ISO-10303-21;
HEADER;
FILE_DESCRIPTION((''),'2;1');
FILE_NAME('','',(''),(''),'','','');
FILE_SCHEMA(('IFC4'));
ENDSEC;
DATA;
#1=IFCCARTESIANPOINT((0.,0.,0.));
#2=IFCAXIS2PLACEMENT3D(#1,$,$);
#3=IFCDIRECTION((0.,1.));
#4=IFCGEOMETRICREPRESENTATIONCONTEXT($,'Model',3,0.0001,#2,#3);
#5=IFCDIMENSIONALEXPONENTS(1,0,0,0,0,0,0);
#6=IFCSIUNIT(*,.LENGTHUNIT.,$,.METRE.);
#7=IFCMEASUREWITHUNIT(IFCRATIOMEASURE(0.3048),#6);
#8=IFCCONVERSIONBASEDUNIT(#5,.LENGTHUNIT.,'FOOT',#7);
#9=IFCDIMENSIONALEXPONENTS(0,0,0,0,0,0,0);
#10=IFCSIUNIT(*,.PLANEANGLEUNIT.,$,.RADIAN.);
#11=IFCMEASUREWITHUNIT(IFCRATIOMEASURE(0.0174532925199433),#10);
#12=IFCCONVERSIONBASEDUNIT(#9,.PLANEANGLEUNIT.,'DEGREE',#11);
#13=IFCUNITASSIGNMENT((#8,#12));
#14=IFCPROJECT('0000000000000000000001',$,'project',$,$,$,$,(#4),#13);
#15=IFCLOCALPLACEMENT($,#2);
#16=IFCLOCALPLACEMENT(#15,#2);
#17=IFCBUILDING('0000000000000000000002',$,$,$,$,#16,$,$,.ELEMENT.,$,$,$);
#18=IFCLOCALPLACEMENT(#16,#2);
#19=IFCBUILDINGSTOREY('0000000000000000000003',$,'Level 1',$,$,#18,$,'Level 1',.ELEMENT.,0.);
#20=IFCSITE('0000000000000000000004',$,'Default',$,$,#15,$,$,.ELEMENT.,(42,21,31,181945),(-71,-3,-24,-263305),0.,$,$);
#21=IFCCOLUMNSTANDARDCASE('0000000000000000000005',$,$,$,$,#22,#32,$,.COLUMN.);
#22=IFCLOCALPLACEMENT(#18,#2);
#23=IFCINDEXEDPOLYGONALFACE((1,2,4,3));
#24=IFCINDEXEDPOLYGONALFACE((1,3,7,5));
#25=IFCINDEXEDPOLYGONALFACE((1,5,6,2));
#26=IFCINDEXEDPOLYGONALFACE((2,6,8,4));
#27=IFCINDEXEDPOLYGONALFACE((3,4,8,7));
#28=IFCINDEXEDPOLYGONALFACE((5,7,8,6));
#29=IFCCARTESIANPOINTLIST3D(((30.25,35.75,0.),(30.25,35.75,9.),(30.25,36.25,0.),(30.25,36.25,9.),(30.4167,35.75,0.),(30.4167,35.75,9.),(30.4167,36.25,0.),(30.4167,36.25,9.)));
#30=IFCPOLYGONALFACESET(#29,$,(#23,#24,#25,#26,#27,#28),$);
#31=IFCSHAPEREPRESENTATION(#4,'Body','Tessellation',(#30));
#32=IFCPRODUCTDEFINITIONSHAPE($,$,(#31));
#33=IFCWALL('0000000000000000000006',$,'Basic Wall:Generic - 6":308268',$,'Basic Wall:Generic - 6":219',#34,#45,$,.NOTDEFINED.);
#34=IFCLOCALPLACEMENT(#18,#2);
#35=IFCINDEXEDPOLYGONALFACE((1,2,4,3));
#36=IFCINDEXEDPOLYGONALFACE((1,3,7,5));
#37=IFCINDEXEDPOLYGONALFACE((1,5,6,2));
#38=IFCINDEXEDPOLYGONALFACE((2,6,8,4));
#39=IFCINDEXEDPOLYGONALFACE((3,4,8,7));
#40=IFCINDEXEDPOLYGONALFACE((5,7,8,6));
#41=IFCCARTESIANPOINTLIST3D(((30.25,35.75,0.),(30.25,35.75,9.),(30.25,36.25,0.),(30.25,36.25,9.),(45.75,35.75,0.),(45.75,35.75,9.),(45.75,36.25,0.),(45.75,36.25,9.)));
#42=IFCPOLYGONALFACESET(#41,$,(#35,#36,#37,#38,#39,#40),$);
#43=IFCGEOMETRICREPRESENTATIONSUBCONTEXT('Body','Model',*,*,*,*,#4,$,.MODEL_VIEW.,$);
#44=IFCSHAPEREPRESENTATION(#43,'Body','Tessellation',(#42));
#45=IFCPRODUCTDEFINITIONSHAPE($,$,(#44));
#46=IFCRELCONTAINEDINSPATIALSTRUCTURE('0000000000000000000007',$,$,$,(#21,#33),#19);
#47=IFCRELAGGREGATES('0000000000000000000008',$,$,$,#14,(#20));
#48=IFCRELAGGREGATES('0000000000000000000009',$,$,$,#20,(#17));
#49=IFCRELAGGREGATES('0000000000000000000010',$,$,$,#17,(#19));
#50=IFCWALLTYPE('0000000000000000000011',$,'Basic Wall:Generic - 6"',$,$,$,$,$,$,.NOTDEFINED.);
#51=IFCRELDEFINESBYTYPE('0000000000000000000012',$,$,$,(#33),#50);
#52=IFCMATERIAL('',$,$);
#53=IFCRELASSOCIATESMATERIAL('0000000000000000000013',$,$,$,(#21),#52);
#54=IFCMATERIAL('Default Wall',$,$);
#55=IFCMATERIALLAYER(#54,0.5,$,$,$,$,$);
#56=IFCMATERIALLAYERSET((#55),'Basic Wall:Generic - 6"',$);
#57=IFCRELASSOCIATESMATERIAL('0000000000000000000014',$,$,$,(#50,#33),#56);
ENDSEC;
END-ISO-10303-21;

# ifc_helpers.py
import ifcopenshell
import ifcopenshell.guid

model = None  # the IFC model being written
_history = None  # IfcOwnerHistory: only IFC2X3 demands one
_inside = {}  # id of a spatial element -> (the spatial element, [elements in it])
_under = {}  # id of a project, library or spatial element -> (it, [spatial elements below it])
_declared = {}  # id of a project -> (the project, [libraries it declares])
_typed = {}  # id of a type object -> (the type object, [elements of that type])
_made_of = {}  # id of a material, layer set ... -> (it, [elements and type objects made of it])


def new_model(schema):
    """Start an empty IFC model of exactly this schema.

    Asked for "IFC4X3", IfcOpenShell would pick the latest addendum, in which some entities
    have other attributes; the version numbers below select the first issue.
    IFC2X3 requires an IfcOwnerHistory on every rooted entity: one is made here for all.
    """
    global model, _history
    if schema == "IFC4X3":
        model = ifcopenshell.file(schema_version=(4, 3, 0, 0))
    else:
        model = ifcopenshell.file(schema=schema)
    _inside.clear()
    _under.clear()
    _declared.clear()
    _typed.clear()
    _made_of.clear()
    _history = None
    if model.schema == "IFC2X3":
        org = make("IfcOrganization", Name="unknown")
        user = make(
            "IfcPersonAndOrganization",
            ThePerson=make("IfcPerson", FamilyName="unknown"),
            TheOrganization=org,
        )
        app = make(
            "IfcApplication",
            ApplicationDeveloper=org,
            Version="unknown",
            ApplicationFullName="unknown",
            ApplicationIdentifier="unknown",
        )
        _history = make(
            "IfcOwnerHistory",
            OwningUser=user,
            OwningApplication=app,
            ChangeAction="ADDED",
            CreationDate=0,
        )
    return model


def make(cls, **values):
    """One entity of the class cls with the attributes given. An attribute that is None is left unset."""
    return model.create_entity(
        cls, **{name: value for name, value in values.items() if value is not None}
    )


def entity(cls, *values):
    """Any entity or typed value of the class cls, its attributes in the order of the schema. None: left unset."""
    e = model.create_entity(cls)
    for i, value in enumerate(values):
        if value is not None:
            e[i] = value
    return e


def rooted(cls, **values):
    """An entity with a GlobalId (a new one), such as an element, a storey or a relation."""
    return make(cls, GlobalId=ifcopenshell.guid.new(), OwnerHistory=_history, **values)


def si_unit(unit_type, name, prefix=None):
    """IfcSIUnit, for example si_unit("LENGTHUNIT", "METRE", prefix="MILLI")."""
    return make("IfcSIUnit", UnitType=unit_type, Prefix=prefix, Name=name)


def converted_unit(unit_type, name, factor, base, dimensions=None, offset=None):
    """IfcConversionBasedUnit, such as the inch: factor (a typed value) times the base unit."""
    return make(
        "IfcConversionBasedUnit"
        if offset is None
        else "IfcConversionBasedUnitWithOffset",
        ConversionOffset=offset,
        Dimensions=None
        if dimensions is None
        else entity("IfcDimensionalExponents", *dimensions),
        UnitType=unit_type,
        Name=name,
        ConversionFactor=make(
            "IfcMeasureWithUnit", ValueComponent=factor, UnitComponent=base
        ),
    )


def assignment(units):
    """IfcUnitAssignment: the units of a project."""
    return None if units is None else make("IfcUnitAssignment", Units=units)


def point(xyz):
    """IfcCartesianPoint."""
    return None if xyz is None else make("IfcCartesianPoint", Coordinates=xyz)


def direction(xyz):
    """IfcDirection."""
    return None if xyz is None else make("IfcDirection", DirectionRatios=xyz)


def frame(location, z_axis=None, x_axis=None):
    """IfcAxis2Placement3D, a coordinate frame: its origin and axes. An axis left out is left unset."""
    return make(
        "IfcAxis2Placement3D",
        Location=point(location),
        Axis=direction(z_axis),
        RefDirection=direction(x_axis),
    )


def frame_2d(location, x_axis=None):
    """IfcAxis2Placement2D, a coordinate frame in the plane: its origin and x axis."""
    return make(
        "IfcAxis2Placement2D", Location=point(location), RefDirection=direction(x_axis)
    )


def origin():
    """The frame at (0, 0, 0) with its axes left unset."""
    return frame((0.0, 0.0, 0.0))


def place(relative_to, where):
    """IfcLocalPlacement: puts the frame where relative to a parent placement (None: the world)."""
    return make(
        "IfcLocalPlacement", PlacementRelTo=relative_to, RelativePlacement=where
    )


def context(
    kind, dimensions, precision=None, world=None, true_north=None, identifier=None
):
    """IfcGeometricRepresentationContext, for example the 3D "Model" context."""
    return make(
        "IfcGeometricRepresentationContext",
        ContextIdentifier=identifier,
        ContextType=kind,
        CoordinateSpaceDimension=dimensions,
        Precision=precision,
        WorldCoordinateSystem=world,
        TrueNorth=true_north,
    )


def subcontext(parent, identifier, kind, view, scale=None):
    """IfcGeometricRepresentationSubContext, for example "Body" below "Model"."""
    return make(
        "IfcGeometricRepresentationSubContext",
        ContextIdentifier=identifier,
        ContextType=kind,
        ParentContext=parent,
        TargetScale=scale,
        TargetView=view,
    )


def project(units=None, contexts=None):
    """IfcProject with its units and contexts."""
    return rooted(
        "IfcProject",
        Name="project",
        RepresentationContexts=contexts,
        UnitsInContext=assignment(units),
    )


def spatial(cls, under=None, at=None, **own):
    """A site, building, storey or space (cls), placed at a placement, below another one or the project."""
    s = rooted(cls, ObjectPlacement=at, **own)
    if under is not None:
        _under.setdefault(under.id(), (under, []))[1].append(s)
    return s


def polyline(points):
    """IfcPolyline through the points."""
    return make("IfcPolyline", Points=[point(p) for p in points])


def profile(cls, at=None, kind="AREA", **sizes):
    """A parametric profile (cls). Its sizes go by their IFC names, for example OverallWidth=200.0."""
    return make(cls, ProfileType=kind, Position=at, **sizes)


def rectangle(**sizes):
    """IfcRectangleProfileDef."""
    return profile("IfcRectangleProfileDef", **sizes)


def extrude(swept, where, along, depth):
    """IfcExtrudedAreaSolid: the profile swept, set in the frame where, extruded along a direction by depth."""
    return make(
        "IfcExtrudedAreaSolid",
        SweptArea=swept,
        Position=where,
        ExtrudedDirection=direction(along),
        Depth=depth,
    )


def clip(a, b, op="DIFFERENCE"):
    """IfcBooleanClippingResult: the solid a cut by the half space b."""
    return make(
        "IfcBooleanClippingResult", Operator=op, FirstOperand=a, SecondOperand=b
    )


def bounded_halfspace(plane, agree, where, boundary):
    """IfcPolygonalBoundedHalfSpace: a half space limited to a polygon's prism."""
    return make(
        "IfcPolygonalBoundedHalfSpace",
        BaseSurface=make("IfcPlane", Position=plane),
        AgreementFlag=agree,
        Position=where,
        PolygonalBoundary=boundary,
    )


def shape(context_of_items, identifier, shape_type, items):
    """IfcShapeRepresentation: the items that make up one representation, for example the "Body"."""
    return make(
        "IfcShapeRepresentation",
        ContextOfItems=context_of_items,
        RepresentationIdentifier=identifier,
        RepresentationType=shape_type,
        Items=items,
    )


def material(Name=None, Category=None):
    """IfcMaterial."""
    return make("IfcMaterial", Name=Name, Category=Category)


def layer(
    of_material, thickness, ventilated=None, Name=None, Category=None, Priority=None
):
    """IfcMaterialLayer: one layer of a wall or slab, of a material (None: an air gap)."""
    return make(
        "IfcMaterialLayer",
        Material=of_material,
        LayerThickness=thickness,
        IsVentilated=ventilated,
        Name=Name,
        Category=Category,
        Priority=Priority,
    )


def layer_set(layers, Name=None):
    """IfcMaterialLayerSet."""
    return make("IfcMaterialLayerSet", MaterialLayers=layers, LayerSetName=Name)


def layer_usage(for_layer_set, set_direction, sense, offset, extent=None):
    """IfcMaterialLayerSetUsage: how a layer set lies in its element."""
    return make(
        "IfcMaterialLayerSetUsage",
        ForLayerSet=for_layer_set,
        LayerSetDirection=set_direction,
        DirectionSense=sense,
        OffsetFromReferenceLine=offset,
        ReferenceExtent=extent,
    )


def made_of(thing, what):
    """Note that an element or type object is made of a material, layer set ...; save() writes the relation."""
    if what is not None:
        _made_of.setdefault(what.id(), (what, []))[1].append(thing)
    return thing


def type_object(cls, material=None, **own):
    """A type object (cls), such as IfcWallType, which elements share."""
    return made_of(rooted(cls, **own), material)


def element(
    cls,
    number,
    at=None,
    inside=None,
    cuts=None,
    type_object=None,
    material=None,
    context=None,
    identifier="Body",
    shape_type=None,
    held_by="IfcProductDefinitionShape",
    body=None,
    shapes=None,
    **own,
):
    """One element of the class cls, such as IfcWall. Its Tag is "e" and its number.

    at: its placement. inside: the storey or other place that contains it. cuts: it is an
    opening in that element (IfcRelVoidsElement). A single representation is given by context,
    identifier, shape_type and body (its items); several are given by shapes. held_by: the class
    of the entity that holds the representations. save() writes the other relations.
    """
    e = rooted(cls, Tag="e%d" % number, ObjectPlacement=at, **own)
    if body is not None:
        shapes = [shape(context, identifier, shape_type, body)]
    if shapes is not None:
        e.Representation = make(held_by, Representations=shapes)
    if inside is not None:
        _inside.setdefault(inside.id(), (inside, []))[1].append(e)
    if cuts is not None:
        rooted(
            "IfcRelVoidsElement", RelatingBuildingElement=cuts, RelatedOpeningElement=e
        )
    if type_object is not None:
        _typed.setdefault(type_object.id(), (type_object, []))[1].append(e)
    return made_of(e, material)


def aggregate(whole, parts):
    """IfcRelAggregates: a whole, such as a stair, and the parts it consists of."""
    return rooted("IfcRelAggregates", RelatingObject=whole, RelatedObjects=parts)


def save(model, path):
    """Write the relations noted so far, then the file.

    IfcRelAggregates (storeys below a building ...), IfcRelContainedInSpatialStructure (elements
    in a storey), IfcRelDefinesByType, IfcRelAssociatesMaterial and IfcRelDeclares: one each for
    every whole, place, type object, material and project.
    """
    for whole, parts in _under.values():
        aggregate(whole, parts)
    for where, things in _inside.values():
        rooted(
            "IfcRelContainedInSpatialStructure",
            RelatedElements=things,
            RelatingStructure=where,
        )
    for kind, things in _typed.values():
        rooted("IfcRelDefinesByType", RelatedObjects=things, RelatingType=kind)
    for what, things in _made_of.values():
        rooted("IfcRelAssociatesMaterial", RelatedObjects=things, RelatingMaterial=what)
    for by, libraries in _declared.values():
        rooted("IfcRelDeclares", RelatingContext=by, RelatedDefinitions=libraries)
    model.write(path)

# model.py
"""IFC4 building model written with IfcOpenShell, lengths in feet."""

from ifc_helpers import new_model, entity, si_unit, converted_unit, direction, frame, frame_2d, origin, place, context, subcontext, project, spatial, polyline, rectangle, extrude, clip, bounded_halfspace, material, layer, layer_set, layer_usage, type_object, element, save


model = new_model("IFC4")

# Units and contexts
model_context = context("Model", 3, precision=0.0001, world=origin(), true_north=direction((0.0, 1.0)))
body_context = subcontext(model_context, "Body", "Model", "MODEL_VIEW")
ifc_project = project(units=[converted_unit("LENGTHUNIT", "FOOT", entity("IfcRatioMeasure", 0.3048), si_unit("LENGTHUNIT", "METRE"), dimensions=[1, 0, 0, 0, 0, 0, 0]), converted_unit("PLANEANGLEUNIT", "DEGREE", entity("IfcRatioMeasure", 0.0174532925199433), si_unit("PLANEANGLEUNIT", "RADIAN"), dimensions=[0, 0, 0, 0, 0, 0, 0])], contexts=[model_context])

# Site, building, storey
site_placement = place(None, origin())
site = spatial("IfcSite", under=ifc_project, at=site_placement, Name="Default", CompositionType="ELEMENT", RefLatitude=(42, 21, 31, 181945), RefLongitude=(-71, -3, -24, -263305), RefElevation=0.0)
building_placement = place(site_placement, origin())
building = spatial("IfcBuilding", under=site, at=building_placement, CompositionType="ELEMENT")
storey_placement = place(building_placement, origin())
storey = spatial("IfcBuildingStorey", under=building, at=storey_placement, Name="Level 1", LongName="Level 1", CompositionType="ELEMENT", Elevation=0.0)

# Column
ifc_material_1 = material(Name="")
wall_placement = place(storey_placement, frame((30.25, 36.0, 0.0)))
for number, where, z_axis, x_axis in (
    (1, (0.0833, 0.0, 0.0), (0.0, 0.0, 1.0), (1.0, 0.0, 0.0)),
):
    element("IfcColumnStandardCase", number, at=place(wall_placement, frame(where, z_axis=z_axis, x_axis=x_axis)), inside=storey, material=ifc_material_1, PredefinedType="COLUMN", context=model_context, shape_type="SweptSolid", body=[
        extrude(rectangle(XDim=0.1667, YDim=0.5), origin(), (0.0, 0.0, 1.0), 9.0),
    ])

# Wall
ifc_material_2 = material(Name="Default Wall")
ifc_layer = layer(ifc_material_2, 0.5)
ifc_layer_set = layer_set([ifc_layer], Name="Basic Wall:Generic - 6\"")
ifc_layer_usage = layer_usage(ifc_layer_set, "AXIS2", "NEGATIVE", 0.25)
wall_type = type_object("IfcWallType", Name="Basic Wall:Generic - 6\"", PredefinedType="NOTDEFINED", material=ifc_layer_set)
element("IfcWall", 2, at=wall_placement, inside=storey, type_object=wall_type, material=ifc_layer_usage, Name="Basic Wall:Generic - 6\":308268", ObjectType="Basic Wall:Generic - 6\":219", PredefinedType="NOTDEFINED", context=body_context, shape_type="Clipping", body=[
    clip(extrude(rectangle(XDim=15.5, YDim=0.5, at=frame_2d((7.75, 0.0), x_axis=(-1.0, 0.0))), origin(), (0.0, 0.0, 1.0), 9.0), bounded_halfspace(frame((0.0, -0.25, 9.0), z_axis=(0.0, 0.0, -1.0), x_axis=(0.0, -1.0, 0.0)), True, frame((0.0, -0.25, 9.0)), polyline([(0.0, 0.0), (15.5, 0.0), (15.5, 0.5), (0.0, 0.5), (0.0, 0.0)]))),
])

save(model, "model.ifc")
